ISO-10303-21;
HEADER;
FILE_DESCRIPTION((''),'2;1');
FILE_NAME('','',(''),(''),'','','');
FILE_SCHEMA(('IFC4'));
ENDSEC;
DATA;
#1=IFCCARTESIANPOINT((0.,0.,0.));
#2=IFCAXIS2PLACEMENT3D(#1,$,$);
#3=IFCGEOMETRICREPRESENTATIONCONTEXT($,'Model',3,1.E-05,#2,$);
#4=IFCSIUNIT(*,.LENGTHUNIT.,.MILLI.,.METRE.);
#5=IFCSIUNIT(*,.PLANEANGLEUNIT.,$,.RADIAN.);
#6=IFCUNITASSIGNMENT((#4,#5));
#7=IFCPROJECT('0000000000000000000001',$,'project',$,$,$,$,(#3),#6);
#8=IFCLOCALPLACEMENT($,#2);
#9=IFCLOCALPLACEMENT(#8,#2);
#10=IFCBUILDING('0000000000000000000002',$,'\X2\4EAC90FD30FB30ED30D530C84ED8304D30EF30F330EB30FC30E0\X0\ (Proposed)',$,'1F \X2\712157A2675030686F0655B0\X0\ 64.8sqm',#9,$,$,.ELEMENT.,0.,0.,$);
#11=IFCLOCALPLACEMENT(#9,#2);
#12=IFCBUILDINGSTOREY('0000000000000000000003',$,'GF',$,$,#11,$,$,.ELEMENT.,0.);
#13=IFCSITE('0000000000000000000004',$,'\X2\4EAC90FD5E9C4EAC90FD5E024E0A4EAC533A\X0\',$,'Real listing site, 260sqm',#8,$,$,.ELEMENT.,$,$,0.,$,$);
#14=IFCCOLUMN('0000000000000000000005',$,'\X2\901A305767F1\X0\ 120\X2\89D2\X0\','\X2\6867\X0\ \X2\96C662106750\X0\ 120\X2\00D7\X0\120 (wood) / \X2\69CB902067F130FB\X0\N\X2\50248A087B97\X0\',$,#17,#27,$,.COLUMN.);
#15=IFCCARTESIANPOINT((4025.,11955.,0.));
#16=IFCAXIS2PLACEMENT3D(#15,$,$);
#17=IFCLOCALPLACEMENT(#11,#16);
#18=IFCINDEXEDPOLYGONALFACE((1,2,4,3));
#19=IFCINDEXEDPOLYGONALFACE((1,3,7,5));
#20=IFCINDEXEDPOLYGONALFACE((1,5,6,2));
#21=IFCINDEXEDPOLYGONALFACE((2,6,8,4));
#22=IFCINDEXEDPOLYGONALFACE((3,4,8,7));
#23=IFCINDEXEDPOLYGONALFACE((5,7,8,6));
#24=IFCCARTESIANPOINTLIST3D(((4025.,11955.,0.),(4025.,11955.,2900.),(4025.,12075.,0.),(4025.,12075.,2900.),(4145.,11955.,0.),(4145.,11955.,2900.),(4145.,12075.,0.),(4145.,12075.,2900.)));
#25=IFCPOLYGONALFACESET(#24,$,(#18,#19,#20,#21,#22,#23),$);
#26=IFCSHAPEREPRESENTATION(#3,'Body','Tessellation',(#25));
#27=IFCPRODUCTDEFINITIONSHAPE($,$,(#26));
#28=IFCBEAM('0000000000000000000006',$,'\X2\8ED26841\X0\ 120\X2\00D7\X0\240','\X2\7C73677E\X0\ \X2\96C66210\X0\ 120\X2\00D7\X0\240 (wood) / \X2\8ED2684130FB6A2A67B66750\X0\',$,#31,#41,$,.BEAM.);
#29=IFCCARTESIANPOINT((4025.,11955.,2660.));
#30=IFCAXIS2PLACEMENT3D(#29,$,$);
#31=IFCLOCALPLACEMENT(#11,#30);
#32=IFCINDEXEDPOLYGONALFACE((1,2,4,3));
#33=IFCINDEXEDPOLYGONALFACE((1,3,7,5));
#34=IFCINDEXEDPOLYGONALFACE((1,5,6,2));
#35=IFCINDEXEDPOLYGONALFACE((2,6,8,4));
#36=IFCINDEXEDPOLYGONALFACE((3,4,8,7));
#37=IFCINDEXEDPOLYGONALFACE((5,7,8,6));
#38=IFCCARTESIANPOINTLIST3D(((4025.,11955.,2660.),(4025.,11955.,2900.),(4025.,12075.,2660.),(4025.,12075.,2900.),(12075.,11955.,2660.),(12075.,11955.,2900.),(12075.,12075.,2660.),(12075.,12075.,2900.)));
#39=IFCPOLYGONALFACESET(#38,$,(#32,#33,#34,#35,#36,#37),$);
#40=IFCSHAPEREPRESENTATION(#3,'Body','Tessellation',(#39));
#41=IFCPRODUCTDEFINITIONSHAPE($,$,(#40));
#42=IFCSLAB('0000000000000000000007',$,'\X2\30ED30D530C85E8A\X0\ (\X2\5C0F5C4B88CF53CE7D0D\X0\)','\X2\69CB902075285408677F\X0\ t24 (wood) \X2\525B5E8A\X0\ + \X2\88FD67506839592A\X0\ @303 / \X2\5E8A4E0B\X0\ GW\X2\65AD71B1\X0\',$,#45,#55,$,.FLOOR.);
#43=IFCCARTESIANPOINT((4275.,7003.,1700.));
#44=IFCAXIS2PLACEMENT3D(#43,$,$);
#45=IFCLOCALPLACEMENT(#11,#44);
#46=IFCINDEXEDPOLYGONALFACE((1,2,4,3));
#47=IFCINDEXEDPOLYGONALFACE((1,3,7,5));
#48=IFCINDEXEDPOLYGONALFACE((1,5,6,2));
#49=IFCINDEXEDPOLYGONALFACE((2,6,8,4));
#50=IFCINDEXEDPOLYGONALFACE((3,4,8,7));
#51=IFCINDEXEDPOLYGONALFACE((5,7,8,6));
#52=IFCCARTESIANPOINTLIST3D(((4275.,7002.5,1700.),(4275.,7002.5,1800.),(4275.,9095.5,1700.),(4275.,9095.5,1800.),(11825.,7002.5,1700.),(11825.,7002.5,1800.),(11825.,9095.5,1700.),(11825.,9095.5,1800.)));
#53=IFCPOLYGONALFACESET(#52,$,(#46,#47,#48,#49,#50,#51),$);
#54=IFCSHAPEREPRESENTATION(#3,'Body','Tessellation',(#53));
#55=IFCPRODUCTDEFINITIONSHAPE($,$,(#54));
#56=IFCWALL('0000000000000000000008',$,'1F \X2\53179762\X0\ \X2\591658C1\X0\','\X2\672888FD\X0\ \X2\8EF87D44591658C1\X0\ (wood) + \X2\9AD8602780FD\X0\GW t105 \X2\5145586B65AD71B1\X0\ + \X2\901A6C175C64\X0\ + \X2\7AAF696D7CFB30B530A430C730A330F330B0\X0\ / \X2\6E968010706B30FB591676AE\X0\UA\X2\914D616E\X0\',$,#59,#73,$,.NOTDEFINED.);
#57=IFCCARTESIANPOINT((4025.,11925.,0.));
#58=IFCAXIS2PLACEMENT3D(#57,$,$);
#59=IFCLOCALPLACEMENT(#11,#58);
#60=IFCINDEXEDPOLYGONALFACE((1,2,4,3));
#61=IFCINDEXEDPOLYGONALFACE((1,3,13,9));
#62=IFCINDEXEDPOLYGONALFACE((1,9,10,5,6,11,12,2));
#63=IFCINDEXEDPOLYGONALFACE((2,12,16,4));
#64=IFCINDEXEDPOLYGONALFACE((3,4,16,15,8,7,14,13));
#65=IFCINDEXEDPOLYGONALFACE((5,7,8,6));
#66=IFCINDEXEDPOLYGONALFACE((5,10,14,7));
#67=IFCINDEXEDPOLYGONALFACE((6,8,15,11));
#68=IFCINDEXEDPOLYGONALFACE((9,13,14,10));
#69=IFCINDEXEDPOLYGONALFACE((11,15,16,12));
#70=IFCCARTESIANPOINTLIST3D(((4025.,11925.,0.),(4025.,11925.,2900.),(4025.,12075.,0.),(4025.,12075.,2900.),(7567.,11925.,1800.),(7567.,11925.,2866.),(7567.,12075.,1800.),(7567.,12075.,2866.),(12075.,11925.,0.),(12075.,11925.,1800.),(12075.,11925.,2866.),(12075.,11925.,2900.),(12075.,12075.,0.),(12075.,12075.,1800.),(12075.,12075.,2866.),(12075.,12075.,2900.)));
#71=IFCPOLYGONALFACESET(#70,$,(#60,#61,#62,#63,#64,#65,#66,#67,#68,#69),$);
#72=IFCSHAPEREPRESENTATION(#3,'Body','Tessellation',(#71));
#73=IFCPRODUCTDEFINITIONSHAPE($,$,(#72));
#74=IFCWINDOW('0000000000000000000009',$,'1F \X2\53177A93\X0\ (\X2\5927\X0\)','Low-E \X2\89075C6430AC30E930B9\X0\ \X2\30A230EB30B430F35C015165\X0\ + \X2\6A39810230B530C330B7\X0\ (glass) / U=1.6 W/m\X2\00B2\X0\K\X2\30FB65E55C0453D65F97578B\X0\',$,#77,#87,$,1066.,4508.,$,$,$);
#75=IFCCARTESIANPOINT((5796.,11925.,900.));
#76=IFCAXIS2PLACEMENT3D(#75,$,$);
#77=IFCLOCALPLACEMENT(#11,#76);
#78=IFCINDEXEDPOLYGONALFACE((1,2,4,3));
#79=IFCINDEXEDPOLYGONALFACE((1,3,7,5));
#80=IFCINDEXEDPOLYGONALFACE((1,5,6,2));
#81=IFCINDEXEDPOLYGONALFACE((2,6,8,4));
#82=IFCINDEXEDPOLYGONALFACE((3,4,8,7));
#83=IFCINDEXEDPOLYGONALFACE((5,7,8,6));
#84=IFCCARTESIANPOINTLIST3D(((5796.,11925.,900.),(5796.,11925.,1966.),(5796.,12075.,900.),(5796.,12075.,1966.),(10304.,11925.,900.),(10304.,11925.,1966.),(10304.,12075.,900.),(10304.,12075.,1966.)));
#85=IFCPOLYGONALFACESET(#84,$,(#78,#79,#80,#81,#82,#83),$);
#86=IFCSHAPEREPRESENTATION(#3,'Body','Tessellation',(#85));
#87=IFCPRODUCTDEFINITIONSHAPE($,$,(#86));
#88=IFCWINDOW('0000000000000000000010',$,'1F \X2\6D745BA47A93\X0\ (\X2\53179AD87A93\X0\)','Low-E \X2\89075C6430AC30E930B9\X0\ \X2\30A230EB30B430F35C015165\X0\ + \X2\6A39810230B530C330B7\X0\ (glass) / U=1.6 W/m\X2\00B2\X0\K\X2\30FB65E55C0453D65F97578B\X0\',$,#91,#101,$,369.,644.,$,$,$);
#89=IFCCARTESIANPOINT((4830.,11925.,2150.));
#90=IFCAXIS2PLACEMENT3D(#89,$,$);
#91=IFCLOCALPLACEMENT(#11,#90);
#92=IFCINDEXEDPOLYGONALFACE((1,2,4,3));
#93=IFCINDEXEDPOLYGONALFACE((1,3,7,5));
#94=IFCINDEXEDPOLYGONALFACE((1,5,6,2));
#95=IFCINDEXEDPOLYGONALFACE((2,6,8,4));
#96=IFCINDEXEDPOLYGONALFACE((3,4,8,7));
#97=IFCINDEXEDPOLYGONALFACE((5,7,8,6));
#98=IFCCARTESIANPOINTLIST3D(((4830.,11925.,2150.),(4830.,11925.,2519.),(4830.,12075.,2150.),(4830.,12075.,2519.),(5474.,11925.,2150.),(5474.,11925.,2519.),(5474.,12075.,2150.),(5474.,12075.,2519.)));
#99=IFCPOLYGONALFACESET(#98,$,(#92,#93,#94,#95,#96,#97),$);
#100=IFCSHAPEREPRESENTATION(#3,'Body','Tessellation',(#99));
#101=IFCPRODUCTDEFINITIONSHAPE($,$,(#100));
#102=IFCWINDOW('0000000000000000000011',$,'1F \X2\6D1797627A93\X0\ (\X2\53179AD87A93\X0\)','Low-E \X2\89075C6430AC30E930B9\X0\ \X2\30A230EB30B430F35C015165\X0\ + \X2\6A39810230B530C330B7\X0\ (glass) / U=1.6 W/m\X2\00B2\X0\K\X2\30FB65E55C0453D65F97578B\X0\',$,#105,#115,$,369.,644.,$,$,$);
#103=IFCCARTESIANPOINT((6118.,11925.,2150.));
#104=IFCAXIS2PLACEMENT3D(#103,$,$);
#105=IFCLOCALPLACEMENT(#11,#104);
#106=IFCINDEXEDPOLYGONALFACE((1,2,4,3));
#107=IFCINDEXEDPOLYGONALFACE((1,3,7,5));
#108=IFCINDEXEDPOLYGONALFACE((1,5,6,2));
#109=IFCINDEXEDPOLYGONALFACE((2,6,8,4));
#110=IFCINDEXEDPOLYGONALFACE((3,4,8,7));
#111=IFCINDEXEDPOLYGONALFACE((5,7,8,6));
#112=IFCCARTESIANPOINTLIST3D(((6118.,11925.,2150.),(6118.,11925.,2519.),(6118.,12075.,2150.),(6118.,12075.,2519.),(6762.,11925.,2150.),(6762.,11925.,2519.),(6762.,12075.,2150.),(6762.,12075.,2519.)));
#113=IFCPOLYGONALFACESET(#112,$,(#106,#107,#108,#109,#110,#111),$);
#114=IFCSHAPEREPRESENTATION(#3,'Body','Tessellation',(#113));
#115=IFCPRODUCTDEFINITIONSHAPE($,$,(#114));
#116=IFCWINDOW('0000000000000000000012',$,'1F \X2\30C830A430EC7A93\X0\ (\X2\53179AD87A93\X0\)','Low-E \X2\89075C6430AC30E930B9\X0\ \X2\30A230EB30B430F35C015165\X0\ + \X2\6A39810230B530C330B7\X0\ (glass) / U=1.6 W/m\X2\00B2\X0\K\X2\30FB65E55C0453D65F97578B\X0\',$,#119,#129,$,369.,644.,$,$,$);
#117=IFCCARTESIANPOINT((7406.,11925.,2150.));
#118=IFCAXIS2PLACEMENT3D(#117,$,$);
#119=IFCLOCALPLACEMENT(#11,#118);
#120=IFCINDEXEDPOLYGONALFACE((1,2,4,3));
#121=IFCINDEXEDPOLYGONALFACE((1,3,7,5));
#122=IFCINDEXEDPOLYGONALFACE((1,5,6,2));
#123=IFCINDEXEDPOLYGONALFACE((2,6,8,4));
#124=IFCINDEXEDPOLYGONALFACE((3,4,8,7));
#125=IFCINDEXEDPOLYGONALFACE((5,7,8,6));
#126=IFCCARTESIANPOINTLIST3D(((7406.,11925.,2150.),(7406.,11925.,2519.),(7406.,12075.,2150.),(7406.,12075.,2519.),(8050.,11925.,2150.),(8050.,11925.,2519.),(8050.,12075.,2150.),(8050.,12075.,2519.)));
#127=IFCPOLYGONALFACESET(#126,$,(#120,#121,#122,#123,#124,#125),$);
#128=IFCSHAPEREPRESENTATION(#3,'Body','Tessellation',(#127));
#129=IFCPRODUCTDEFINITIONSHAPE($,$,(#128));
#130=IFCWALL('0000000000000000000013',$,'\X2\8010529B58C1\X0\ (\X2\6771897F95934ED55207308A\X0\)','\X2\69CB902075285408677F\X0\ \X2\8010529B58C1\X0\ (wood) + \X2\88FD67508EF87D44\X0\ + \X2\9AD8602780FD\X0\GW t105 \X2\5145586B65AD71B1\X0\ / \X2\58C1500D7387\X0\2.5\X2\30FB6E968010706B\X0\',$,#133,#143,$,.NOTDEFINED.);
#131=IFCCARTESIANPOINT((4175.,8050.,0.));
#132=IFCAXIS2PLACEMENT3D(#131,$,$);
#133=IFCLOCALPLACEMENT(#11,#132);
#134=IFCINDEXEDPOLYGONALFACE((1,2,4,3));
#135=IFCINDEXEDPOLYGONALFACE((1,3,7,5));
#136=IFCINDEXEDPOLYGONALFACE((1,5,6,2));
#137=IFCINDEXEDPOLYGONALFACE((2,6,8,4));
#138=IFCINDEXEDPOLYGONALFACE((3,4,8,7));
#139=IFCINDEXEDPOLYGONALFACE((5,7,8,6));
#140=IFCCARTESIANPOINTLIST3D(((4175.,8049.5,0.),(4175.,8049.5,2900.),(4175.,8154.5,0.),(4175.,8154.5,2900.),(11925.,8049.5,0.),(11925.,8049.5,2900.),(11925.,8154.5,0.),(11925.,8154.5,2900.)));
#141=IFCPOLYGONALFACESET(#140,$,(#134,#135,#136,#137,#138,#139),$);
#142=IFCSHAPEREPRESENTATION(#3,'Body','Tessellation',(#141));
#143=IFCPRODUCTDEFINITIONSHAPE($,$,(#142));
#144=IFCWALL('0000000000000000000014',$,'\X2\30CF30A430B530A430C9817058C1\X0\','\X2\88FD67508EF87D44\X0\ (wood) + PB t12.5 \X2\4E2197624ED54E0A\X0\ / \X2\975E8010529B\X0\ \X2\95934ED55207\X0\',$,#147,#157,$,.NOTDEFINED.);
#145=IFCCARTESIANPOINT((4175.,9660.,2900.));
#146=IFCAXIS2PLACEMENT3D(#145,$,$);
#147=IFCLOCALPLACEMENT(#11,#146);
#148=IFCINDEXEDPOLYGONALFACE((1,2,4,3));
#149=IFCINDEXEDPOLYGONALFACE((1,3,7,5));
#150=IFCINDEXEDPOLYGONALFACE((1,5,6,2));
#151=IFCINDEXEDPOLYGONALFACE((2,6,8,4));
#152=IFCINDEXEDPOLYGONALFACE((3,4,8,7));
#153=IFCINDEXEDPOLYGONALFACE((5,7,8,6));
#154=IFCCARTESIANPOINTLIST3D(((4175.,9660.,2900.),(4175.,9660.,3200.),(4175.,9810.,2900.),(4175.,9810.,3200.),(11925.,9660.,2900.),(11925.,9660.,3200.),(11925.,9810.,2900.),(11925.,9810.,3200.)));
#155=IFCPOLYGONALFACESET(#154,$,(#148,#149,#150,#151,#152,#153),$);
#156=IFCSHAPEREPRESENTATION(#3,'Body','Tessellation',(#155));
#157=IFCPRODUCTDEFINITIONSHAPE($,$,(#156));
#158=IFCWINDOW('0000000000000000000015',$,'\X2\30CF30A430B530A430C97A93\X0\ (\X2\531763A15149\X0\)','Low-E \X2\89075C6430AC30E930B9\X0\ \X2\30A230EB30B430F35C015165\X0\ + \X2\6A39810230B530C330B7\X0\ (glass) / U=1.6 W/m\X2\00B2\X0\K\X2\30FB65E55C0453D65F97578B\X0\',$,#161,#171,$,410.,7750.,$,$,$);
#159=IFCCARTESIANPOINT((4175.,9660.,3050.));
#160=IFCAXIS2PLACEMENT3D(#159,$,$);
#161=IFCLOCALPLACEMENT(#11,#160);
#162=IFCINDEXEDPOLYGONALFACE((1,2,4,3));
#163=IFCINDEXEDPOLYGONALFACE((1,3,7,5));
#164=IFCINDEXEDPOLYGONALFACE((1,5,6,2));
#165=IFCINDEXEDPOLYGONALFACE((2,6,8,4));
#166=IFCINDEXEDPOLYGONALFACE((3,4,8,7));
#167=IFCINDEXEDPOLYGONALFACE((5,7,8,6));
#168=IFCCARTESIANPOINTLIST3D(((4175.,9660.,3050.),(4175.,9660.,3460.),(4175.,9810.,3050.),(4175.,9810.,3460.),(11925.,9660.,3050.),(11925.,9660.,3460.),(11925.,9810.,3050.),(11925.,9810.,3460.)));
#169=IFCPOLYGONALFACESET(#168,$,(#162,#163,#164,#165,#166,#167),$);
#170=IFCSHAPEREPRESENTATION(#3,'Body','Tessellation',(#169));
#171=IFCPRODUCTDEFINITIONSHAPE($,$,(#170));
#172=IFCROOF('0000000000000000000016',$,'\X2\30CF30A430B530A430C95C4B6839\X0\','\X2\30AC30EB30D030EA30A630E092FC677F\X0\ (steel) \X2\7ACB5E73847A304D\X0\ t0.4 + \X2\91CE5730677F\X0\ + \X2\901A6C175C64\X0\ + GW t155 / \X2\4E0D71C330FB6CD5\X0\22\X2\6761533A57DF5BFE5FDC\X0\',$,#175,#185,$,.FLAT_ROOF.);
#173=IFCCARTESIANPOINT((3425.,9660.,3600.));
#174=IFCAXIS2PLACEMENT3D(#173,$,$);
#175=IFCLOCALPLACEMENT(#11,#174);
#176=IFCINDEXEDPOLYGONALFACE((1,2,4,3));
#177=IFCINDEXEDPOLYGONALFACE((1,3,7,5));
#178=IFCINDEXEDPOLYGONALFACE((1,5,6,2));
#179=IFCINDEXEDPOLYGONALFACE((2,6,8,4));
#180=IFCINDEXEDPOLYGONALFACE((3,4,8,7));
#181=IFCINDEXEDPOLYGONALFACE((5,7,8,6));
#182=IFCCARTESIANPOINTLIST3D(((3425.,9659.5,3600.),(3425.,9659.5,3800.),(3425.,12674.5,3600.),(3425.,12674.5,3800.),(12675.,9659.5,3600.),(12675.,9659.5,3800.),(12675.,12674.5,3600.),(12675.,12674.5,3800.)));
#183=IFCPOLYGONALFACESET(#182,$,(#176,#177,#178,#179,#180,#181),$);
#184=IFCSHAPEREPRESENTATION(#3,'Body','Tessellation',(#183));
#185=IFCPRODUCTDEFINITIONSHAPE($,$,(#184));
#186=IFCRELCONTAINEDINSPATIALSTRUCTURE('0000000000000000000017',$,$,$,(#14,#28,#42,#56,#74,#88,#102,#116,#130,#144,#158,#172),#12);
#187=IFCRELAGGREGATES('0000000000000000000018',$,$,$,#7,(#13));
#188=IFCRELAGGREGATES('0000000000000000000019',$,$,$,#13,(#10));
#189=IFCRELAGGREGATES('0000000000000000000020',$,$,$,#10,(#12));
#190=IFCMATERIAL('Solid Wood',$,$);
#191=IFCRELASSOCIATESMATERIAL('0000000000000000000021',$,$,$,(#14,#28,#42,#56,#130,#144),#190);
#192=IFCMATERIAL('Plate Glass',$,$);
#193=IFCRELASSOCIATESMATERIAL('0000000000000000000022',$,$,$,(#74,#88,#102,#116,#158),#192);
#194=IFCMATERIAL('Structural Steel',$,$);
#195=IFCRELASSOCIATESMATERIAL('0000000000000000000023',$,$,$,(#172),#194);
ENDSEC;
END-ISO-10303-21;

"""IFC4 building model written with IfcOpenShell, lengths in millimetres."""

from ifc_helpers import new_model, si_unit, frame, frame_2d, origin, place, context, project, spatial, rectangle, extrude, material, element, fill, save


model = new_model("IFC4")

# Units and contexts
model_context = context("Model", 3, precision=1e-05, world=origin())
ifc_project = project(units=[si_unit("LENGTHUNIT", "METRE", prefix="MILLI"), si_unit("PLANEANGLEUNIT", "RADIAN")], contexts=[model_context])

# Site, building, storey
site_placement = place(None, origin())
site = spatial("IfcSite", under=ifc_project, at=site_placement, Name="京都府京都市上京区", ObjectType="Real listing site, 260sqm", CompositionType="ELEMENT", RefElevation=0.0)
building_placement = place(site_placement, origin())
building = spatial("IfcBuilding", under=site, at=building_placement, Name="京都・ロフト付きワンルーム (Proposed)", ObjectType="1F 無垢材と漆喰 64.8sqm", CompositionType="ELEMENT", ElevationOfRefHeight=0.0, ElevationOfTerrain=0.0)
storey_placement = place(building_placement, origin())
storey = spatial("IfcBuildingStorey", under=building, at=storey_placement, Name="GF", CompositionType="ELEMENT", Elevation=0.0)

# Column
ifc_material_1 = material(Name="Solid Wood")
column_1_placement = place(storey_placement, frame((4025.0, 11955.0, 0.0)))
element("IfcColumn", 1, at=column_1_placement, inside=storey, material=ifc_material_1, Name="通し柱 120角", Description="桧 集成材 120×120 (wood) / 構造柱・N値計算", PredefinedType="COLUMN", context=model_context, shape_type="SweptSolid", body=[
    extrude(rectangle(XDim=120.0, YDim=120.0, at=frame_2d((60.0, 60.0))), frame((4025.0, 11955.0, 0.0)), (0.0, 0.0, 1.0), 2900.0),
])

# Beam
beam_1_placement = place(storey_placement, frame((4025.0, 11955.0, 2660.0)))
element("IfcBeam", 2, at=beam_1_placement, inside=storey, material=ifc_material_1, Name="軒桁 120×240", Description="米松 集成 120×240 (wood) / 軒桁・横架材", PredefinedType="BEAM", context=model_context, shape_type="SweptSolid", body=[
    extrude(rectangle(XDim=8050.0, YDim=120.0, at=frame_2d((4025.0, 60.0))), frame((4025.0, 11955.0, 2660.0)), (0.0, 0.0, 1.0), 240.0),
])

# Slab
slab_placement = place(storey_placement, frame((4275.0, 7003.0, 1700.0)))
element("IfcSlab", 3, at=slab_placement, inside=storey, material=ifc_material_1, Name="ロフト床 (小屋裏収納)", Description="構造用合板 t24 (wood) 剛床 + 製材根太 @303 / 床下 GW断熱", PredefinedType="FLOOR", context=model_context, shape_type="SweptSolid", body=[
    extrude(rectangle(XDim=7550.0, YDim=2093.0, at=frame_2d((3775.0, 1046.0))), frame((4275.0, 7003.0, 1700.0)), (0.0, 0.0, 1.0), 100.0),
])

# Wall, openings, windows
wall_1_placement = place(storey_placement, frame((4025.0, 11925.0, 0.0)))
wall_1 = element("IfcWall", 4, at=wall_1_placement, inside=storey, material=ifc_material_1, Name="1F 北面 外壁", Description="木製 軸組外壁 (wood) + 高性能GW t105 充填断熱 + 通気層 + 窯業系サイディング / 準耐火・外皮UA配慮", PredefinedType="NOTDEFINED", context=model_context, shape_type="SweptSolid", body=[
    extrude(rectangle(XDim=8050.0, YDim=150.0, at=frame_2d((4025.0, 75.0))), frame((4025.0, 11925.0, 0.0)), (0.0, 0.0, 1.0), 2900.0),
])
opening_1_placement = place(storey_placement, frame((5796.0, 11925.0, 900.0)))
opening_1 = element("IfcOpeningElement", 5, at=opening_1_placement, cuts=wall_1, PredefinedType="NOTDEFINED", context=model_context, shape_type="SweptSolid", body=[
    extrude(rectangle(XDim=4508.0, YDim=150.0, at=frame_2d((2254.0, 75.0))), frame((5796.0, 11925.0, 900.0)), (0.0, 0.0, 1.0), 1066.0),
])
opening_2_placement = place(storey_placement, frame((4830.0, 11925.0, 2150.0)))
opening_2 = element("IfcOpeningElement", 6, at=opening_2_placement, cuts=wall_1, PredefinedType="NOTDEFINED", context=model_context, shape_type="SweptSolid", body=[
    extrude(rectangle(XDim=644.0, YDim=150.0, at=frame_2d((322.0, 75.0))), frame((4830.0, 11925.0, 2150.0)), (0.0, 0.0, 1.0), 369.0),
])
opening_3_placement = place(storey_placement, frame((6118.0, 11925.0, 2150.0)))
opening_3 = element("IfcOpeningElement", 7, at=opening_3_placement, cuts=wall_1, PredefinedType="NOTDEFINED", context=model_context, shape_type="SweptSolid", body=[
    extrude(rectangle(XDim=644.0, YDim=150.0, at=frame_2d((322.0, 75.0))), frame((6118.0, 11925.0, 2150.0)), (0.0, 0.0, 1.0), 369.0),
])
opening_4_placement = place(storey_placement, frame((7406.0, 11925.0, 2150.0)))
opening_4 = element("IfcOpeningElement", 8, at=opening_4_placement, cuts=wall_1, PredefinedType="NOTDEFINED", context=model_context, shape_type="SweptSolid", body=[
    extrude(rectangle(XDim=644.0, YDim=150.0, at=frame_2d((322.0, 75.0))), frame((7406.0, 11925.0, 2150.0)), (0.0, 0.0, 1.0), 369.0),
])
ifc_material_2 = material(Name="Plate Glass")
window_1_placement = place(storey_placement, frame((5796.0, 11925.0, 900.0)))
window_1 = element("IfcWindow", 9, at=window_1_placement, inside=storey, material=ifc_material_2, Name="1F 北窓 (大)", Description="Low-E 複層ガラス アルゴン封入 + 樹脂サッシ (glass) / U=1.6 W/m²K・日射取得型", OverallHeight=1066.0, OverallWidth=4508.0, context=model_context, shape_type="SweptSolid", body=[
    extrude(rectangle(XDim=4508.0, YDim=150.0, at=frame_2d((2254.0, 75.0))), frame((5796.0, 11925.0, 900.0)), (0.0, 0.0, 1.0), 1066.0),
])
fill(opening_1, window_1)
window_2_placement = place(storey_placement, frame((4830.0, 11925.0, 2150.0)))
window_2 = element("IfcWindow", 10, at=window_2_placement, inside=storey, material=ifc_material_2, Name="1F 浴室窓 (北高窓)", Description="Low-E 複層ガラス アルゴン封入 + 樹脂サッシ (glass) / U=1.6 W/m²K・日射取得型", OverallHeight=369.0, OverallWidth=644.0, context=model_context, shape_type="SweptSolid", body=[
    extrude(rectangle(XDim=644.0, YDim=150.0, at=frame_2d((322.0, 75.0))), frame((4830.0, 11925.0, 2150.0)), (0.0, 0.0, 1.0), 369.0),
])
fill(opening_2, window_2)
window_3_placement = place(storey_placement, frame((6118.0, 11925.0, 2150.0)))
window_3 = element("IfcWindow", 11, at=window_3_placement, inside=storey, material=ifc_material_2, Name="1F 洗面窓 (北高窓)", Description="Low-E 複層ガラス アルゴン封入 + 樹脂サッシ (glass) / U=1.6 W/m²K・日射取得型", OverallHeight=369.0, OverallWidth=644.0, context=model_context, shape_type="SweptSolid", body=[
    extrude(rectangle(XDim=644.0, YDim=150.0, at=frame_2d((322.0, 75.0))), frame((6118.0, 11925.0, 2150.0)), (0.0, 0.0, 1.0), 369.0),
])
fill(opening_3, window_3)
window_4_placement = place(storey_placement, frame((7406.0, 11925.0, 2150.0)))
window_4 = element("IfcWindow", 12, at=window_4_placement, inside=storey, material=ifc_material_2, Name="1F トイレ窓 (北高窓)", Description="Low-E 複層ガラス アルゴン封入 + 樹脂サッシ (glass) / U=1.6 W/m²K・日射取得型", OverallHeight=369.0, OverallWidth=644.0, context=model_context, shape_type="SweptSolid", body=[
    extrude(rectangle(XDim=644.0, YDim=150.0, at=frame_2d((322.0, 75.0))), frame((7406.0, 11925.0, 2150.0)), (0.0, 0.0, 1.0), 369.0),
])
fill(opening_4, window_4)

# Wall
wall_2_placement = place(storey_placement, frame((4175.0, 8050.0, 0.0)))
element("IfcWall", 13, at=wall_2_placement, inside=storey, material=ifc_material_1, Name="耐力壁 (東西間仕切り)", Description="構造用合板 耐力壁 (wood) + 製材軸組 + 高性能GW t105 充填断熱 / 壁倍率2.5・準耐火", PredefinedType="NOTDEFINED", context=model_context, shape_type="SweptSolid", body=[
    extrude(rectangle(XDim=7750.0, YDim=105.0, at=frame_2d((3875.0, 52.0))), frame((4175.0, 8050.0, 0.0)), (0.0, 0.0, 1.0), 2900.0),
])

# Wall, opening, window
wall_3_placement = place(storey_placement, frame((4175.0, 9660.0, 2900.0)))
wall_3 = element("IfcWall", 14, at=wall_3_placement, inside=storey, material=ifc_material_1, Name="ハイサイド腰壁", Description="製材軸組 (wood) + PB t12.5 両面仕上 / 非耐力 間仕切", PredefinedType="NOTDEFINED", context=model_context, shape_type="SweptSolid", body=[
    extrude(rectangle(XDim=7750.0, YDim=150.0, at=frame_2d((3875.0, 75.0))), frame((4175.0, 9660.0, 2900.0)), (0.0, 0.0, 1.0), 700.0),
])
opening_5_placement = place(storey_placement, frame((4175.0, 9660.0, 3050.0)))
opening_5 = element("IfcOpeningElement", 15, at=opening_5_placement, cuts=wall_3, PredefinedType="NOTDEFINED", context=model_context, shape_type="SweptSolid", body=[
    extrude(rectangle(XDim=7750.0, YDim=150.0, at=frame_2d((3875.0, 75.0))), frame((4175.0, 9660.0, 3050.0)), (0.0, 0.0, 1.0), 410.0),
])
window_5_placement = place(storey_placement, frame((4175.0, 9660.0, 3050.0)))
window_5 = element("IfcWindow", 16, at=window_5_placement, inside=storey, material=ifc_material_2, Name="ハイサイド窓 (北採光)", Description="Low-E 複層ガラス アルゴン封入 + 樹脂サッシ (glass) / U=1.6 W/m²K・日射取得型", OverallHeight=410.0, OverallWidth=7750.0, context=model_context, shape_type="SweptSolid", body=[
    extrude(rectangle(XDim=7750.0, YDim=150.0, at=frame_2d((3875.0, 75.0))), frame((4175.0, 9660.0, 3050.0)), (0.0, 0.0, 1.0), 410.0),
])
fill(opening_5, window_5)

# Roof
ifc_material_3 = material(Name="Structural Steel")
roof_placement = place(storey_placement, frame((3425.0, 9660.0, 3600.0)))
element("IfcRoof", 17, at=roof_placement, inside=storey, material=ifc_material_3, Name="ハイサイド屋根", Description="ガルバリウム鋼板 (steel) 立平葺き t0.4 + 野地板 + 通気層 + GW t155 / 不燃・法22条区域対応", PredefinedType="FLAT_ROOF", context=model_context, shape_type="SweptSolid", body=[
    extrude(rectangle(XDim=9250.0, YDim=3015.0, at=frame_2d((4625.0, 1507.0))), frame((3425.0, 9660.0, 3600.0)), (0.0, 0.0, 1.0), 200.0),
])

save(model, "model.ifc")
